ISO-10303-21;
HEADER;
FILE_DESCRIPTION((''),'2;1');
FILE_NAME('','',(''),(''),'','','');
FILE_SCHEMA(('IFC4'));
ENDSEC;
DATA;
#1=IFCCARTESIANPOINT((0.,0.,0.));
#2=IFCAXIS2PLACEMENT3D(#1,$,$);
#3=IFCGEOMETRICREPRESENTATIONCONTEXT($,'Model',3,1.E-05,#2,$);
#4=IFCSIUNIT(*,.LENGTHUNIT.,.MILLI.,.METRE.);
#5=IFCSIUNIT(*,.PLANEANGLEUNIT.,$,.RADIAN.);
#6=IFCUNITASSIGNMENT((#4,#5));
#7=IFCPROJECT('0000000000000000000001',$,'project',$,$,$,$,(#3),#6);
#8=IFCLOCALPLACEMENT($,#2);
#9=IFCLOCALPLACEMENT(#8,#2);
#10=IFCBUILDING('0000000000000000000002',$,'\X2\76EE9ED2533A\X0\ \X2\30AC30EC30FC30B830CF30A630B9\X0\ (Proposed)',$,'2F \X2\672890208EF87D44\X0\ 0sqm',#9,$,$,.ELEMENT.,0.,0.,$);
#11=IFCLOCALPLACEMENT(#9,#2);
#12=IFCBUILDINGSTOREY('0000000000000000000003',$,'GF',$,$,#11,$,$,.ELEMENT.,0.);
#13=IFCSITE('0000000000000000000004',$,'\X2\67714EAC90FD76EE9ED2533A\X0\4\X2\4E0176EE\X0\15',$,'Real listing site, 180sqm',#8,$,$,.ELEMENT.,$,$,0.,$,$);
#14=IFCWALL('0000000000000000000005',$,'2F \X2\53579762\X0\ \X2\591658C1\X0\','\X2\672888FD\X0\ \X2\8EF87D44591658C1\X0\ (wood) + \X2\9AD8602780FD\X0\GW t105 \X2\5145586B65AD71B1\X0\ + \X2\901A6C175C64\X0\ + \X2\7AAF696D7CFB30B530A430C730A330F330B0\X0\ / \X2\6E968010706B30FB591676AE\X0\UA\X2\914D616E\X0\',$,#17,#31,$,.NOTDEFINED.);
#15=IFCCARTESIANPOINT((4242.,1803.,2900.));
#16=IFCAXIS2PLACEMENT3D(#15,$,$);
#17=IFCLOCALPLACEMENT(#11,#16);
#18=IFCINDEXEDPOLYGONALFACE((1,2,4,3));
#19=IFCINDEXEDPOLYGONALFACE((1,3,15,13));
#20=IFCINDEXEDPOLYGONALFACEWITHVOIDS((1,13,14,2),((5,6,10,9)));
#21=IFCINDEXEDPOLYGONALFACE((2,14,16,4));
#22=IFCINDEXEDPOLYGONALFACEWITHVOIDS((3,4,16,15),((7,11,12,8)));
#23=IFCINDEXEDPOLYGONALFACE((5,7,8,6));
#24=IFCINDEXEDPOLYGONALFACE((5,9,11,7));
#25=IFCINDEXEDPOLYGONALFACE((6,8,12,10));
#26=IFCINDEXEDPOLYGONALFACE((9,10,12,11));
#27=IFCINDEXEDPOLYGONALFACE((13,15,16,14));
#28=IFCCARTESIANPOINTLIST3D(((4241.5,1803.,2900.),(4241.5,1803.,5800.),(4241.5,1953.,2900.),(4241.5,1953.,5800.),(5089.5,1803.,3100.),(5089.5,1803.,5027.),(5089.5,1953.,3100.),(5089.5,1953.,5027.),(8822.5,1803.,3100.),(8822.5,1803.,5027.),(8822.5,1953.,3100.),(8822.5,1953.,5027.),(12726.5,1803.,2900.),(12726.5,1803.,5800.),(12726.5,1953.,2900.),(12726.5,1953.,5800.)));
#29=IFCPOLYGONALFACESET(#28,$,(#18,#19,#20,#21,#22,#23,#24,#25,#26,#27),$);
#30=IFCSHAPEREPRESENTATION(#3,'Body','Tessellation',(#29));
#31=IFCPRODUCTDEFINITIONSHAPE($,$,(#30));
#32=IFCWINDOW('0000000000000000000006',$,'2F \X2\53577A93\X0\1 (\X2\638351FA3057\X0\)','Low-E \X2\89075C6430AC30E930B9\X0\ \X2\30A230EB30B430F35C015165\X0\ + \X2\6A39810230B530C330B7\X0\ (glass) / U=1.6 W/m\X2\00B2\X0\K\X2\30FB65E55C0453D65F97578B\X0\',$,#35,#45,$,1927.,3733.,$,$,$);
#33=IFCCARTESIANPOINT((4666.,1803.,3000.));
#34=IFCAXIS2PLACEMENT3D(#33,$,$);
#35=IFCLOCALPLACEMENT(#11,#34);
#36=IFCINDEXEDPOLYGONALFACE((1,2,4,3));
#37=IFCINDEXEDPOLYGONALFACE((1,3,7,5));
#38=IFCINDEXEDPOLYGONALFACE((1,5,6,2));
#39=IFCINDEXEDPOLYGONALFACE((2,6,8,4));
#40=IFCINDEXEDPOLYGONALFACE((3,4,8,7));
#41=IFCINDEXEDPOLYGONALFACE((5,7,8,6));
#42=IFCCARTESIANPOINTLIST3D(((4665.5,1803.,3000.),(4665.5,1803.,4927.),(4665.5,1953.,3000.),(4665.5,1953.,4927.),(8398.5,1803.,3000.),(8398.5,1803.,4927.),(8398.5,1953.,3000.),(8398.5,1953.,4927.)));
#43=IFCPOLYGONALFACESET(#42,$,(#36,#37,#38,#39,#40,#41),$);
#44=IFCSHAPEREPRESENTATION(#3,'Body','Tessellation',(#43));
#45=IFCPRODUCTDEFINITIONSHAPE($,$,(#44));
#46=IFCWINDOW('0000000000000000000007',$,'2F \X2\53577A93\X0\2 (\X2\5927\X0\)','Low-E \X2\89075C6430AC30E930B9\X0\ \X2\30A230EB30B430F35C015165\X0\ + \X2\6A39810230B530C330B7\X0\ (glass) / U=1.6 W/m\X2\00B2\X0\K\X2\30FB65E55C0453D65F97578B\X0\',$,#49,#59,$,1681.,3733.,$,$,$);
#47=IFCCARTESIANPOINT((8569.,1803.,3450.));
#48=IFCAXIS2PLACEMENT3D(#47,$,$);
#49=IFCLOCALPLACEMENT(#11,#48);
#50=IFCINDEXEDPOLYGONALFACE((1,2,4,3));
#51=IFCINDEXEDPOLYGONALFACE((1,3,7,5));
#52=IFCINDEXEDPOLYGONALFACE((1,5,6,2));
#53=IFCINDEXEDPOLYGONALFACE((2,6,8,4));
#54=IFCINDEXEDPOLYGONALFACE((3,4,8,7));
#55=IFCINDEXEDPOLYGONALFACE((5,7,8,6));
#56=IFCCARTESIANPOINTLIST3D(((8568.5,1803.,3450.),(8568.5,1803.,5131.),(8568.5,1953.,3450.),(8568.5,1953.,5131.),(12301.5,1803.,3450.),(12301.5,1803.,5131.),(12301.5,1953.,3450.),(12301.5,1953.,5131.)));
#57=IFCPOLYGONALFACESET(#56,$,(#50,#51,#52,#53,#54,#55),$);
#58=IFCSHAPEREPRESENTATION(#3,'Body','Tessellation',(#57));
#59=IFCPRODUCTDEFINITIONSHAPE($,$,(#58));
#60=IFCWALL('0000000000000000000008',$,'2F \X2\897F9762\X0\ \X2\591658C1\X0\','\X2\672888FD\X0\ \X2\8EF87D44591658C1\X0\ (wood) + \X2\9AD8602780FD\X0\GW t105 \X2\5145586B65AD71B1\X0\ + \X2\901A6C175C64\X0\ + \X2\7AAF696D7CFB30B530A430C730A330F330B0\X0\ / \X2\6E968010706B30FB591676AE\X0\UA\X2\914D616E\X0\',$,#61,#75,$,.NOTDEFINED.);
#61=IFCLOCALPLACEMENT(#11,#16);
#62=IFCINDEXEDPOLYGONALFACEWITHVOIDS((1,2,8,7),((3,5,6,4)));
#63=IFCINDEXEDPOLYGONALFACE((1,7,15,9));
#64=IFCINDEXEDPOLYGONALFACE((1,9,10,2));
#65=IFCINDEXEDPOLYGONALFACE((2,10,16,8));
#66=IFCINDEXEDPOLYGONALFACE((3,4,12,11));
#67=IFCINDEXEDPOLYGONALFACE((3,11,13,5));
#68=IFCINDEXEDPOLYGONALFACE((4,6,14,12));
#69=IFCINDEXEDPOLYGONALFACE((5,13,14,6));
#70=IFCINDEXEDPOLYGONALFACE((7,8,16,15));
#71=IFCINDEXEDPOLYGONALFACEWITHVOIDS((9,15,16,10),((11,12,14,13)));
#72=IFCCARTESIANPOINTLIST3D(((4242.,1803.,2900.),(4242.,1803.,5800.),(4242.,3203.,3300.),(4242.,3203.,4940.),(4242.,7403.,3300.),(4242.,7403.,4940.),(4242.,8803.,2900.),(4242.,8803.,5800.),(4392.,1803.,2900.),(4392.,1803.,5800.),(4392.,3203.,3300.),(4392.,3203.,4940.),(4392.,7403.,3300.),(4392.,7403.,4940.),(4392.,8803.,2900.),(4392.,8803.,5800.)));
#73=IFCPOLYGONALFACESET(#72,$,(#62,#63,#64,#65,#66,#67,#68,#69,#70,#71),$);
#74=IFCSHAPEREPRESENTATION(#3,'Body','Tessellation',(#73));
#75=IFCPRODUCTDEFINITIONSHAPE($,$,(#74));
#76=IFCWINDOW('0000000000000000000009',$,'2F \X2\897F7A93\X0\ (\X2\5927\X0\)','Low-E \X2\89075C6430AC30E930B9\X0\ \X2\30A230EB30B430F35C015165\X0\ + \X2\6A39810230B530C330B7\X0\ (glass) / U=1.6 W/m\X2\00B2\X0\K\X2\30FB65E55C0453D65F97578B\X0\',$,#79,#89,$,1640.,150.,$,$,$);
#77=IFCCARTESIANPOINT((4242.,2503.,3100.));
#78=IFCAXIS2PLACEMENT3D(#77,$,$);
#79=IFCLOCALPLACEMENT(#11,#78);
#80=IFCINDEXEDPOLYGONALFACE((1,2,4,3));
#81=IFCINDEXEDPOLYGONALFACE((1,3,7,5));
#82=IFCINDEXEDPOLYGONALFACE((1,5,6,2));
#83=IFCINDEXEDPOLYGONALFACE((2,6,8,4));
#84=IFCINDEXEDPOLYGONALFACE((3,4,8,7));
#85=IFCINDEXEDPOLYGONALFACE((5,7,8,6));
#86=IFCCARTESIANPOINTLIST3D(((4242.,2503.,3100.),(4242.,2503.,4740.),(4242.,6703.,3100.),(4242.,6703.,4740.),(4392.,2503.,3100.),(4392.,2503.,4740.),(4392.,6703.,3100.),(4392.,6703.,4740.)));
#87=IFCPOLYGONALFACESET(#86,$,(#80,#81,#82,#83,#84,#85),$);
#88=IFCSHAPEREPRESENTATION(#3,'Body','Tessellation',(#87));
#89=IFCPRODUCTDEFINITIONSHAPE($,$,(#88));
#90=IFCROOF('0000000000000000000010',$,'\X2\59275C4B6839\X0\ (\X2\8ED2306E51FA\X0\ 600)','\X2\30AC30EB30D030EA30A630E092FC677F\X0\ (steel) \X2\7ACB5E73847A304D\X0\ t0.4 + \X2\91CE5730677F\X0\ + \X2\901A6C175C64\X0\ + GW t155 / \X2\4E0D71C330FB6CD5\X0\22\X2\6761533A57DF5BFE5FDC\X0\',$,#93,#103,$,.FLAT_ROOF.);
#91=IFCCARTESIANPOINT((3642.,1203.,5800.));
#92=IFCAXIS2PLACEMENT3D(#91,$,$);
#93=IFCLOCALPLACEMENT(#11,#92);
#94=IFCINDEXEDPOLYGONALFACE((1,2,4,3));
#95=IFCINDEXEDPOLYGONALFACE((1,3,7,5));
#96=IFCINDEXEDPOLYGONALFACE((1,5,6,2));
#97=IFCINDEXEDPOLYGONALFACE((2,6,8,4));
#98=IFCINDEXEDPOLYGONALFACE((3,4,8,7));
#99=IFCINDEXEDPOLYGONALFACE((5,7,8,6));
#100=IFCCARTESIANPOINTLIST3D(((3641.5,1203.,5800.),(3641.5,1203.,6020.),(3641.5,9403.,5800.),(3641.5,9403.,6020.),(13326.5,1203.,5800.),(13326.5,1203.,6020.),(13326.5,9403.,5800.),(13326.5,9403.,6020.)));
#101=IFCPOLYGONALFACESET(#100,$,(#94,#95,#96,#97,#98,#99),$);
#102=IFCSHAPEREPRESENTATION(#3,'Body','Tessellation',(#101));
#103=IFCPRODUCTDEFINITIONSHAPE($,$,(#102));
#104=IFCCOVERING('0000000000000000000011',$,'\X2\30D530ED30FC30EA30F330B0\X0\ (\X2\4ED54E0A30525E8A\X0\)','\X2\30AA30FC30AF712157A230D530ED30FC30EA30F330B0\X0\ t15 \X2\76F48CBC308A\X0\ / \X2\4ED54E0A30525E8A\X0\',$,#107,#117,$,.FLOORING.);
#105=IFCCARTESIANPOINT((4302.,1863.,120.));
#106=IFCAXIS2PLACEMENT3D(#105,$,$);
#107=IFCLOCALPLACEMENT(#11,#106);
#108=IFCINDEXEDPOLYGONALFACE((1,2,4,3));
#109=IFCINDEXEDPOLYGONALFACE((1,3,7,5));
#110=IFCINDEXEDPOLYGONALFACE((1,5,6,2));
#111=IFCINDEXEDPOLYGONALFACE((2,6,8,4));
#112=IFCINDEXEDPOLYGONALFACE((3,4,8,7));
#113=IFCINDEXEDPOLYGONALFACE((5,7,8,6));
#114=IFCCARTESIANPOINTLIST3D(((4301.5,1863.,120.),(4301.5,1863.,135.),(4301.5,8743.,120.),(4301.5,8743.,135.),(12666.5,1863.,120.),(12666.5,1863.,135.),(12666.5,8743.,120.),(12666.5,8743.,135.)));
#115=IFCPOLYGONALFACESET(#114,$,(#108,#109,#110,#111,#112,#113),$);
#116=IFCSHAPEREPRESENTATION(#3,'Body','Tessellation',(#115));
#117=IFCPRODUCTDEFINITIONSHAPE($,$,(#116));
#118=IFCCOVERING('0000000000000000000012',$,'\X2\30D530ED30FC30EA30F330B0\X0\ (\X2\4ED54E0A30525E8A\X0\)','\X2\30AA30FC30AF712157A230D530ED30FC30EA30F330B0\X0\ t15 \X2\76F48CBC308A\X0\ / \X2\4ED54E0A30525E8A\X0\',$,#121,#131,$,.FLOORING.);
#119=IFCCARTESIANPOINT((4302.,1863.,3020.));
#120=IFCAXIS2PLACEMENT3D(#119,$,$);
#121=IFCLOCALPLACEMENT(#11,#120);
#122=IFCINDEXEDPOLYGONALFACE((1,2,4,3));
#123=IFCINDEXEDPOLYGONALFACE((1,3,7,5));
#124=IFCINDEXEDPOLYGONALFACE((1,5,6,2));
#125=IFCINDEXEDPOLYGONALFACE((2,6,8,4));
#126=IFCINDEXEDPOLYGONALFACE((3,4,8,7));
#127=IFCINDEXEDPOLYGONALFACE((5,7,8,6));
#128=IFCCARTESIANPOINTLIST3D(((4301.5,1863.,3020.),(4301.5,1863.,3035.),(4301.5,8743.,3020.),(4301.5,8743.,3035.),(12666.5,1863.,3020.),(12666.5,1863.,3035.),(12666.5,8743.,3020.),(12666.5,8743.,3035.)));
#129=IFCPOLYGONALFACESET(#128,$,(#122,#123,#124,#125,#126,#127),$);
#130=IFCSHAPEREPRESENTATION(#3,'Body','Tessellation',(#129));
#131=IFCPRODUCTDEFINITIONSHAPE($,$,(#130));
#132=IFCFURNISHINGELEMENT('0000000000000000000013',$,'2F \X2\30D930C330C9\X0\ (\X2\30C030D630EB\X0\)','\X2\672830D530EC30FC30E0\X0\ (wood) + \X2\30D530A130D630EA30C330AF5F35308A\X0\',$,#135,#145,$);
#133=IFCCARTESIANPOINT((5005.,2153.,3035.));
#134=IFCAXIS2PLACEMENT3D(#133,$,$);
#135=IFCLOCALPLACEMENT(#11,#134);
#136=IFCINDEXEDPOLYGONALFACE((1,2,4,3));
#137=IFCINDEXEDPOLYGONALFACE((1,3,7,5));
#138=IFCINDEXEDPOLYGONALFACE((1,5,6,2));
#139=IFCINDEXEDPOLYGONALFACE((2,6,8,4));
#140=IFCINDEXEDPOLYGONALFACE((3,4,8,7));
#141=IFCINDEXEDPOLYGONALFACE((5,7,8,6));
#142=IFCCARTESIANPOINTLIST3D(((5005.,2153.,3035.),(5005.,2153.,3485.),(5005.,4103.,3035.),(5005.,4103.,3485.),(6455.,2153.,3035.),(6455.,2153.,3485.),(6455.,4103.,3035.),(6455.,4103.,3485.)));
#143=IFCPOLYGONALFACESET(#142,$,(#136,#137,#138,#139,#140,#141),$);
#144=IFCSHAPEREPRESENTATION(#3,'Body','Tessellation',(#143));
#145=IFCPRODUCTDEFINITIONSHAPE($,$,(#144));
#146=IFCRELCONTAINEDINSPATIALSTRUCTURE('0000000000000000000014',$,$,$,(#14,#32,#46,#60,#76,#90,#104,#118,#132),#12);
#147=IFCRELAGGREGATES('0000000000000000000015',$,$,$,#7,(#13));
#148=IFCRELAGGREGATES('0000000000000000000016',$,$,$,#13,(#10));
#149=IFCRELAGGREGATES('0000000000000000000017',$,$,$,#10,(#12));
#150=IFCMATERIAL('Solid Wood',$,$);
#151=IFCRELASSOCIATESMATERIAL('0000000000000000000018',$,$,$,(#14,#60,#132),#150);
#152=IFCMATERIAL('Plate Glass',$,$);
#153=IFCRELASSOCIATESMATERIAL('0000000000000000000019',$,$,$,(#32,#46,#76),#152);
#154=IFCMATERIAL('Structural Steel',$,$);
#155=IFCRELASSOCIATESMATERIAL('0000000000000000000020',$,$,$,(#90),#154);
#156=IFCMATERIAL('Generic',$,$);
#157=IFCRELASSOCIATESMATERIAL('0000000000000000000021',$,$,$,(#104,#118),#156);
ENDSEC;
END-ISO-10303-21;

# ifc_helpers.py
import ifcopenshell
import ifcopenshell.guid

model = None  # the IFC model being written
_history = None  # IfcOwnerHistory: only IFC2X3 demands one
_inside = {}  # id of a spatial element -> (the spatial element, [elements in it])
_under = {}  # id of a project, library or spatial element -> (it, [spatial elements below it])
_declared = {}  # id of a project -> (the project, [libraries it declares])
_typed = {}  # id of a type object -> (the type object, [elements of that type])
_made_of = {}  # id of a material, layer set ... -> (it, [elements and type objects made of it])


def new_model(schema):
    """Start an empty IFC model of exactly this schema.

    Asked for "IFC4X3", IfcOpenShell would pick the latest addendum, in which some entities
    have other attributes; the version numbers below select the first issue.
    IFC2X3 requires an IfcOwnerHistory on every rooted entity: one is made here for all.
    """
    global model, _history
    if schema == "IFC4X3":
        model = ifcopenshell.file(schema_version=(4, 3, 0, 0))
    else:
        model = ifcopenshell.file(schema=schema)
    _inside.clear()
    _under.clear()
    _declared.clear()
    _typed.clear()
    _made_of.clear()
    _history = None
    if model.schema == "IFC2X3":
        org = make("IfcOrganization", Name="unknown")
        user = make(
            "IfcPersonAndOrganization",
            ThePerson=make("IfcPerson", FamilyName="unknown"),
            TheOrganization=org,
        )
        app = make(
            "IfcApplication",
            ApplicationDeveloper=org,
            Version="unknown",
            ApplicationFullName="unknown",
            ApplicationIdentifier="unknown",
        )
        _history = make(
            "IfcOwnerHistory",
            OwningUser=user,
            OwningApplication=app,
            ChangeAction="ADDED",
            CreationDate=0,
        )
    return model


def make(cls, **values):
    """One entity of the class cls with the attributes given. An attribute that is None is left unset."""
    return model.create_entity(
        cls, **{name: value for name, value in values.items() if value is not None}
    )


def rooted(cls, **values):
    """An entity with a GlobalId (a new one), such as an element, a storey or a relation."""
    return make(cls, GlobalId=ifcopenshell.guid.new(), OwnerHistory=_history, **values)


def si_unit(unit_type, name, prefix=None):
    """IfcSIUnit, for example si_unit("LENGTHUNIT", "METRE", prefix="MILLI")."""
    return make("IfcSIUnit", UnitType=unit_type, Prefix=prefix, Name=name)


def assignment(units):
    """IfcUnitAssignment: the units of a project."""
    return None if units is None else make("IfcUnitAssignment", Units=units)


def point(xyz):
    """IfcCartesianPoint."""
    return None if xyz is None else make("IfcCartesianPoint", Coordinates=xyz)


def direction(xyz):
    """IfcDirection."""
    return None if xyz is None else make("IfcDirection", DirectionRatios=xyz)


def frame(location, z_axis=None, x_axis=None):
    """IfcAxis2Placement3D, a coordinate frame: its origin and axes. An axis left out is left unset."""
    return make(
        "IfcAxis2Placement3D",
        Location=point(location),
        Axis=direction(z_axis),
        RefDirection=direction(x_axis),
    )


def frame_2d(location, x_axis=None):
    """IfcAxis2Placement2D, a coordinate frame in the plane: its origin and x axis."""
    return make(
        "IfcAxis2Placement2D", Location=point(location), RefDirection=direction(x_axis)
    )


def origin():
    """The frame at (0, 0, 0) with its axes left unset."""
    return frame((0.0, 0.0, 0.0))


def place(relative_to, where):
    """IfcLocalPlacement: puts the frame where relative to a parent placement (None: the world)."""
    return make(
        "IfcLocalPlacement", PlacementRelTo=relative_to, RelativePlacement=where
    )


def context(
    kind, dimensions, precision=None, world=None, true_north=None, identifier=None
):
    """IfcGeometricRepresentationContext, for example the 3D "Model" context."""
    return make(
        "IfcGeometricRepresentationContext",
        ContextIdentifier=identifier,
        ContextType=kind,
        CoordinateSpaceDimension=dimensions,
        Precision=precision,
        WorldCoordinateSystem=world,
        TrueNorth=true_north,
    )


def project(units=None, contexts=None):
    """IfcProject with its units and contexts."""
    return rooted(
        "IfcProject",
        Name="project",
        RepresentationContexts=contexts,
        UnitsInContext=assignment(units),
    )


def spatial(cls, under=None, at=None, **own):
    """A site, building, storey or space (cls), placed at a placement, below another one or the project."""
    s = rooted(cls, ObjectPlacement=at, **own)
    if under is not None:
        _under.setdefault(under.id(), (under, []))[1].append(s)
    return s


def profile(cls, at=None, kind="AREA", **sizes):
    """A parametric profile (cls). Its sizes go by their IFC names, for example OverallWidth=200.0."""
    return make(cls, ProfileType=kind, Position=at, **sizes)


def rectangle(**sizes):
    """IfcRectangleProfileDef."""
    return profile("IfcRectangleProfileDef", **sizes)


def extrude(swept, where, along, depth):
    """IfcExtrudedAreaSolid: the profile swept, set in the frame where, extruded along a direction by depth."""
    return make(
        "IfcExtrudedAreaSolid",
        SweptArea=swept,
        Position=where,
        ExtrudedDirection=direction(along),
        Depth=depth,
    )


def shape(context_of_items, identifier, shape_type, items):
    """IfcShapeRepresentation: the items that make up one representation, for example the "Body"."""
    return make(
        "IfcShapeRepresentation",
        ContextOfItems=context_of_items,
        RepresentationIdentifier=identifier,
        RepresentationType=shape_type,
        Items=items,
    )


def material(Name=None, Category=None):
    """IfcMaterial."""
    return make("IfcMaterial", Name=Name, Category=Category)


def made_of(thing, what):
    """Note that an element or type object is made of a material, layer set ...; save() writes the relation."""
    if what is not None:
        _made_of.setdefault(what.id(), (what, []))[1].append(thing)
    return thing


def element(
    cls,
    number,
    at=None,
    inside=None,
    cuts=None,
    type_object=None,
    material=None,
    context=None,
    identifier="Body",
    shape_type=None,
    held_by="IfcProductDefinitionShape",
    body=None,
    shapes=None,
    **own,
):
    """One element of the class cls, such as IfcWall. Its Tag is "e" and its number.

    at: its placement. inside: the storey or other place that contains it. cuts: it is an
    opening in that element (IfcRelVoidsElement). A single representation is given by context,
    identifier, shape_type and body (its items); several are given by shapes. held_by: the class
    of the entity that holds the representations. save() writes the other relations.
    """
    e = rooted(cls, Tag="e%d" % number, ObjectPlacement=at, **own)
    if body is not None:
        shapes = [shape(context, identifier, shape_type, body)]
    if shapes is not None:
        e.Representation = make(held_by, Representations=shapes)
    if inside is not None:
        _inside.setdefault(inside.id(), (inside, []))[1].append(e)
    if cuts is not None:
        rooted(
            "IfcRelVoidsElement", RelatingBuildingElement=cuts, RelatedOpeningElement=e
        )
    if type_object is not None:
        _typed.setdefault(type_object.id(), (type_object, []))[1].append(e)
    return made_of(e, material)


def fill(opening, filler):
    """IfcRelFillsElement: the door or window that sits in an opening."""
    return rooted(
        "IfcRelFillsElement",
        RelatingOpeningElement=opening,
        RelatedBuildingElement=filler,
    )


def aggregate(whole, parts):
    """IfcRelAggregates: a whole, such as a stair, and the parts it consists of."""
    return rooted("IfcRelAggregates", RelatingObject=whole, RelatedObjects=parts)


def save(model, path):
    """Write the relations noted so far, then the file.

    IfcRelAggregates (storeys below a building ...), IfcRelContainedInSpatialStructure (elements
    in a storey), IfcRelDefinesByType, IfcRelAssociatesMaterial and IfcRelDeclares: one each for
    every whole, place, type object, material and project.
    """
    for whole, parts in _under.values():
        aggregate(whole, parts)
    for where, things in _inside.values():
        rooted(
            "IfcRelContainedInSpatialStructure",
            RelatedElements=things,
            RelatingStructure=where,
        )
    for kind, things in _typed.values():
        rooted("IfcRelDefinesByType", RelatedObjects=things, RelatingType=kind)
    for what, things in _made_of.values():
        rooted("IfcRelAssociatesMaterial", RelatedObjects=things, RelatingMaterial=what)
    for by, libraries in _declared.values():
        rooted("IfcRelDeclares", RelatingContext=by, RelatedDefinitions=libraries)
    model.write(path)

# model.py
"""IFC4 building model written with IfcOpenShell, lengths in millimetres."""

from ifc_helpers import new_model, si_unit, frame, frame_2d, origin, place, context, project, spatial, rectangle, extrude, material, element, fill, save


model = new_model("IFC4")

# Units and contexts
model_context = context("Model", 3, precision=1e-05, world=origin())
ifc_project = project(units=[si_unit("LENGTHUNIT", "METRE", prefix="MILLI"), si_unit("PLANEANGLEUNIT", "RADIAN")], contexts=[model_context])

# Site, building, storey
site_placement = place(None, origin())
site = spatial("IfcSite", under=ifc_project, at=site_placement, Name="東京都目黒区4丁目15", ObjectType="Real listing site, 180sqm", CompositionType="ELEMENT", RefElevation=0.0)
building_placement = place(site_placement, origin())
building = spatial("IfcBuilding", under=site, at=building_placement, Name="目黒区 ガレージハウス (Proposed)", ObjectType="2F 木造軸組 0sqm", CompositionType="ELEMENT", ElevationOfRefHeight=0.0, ElevationOfTerrain=0.0)
storey_placement = place(building_placement, origin())
storey = spatial("IfcBuildingStorey", under=building, at=storey_placement, Name="GF", CompositionType="ELEMENT", Elevation=0.0)

# Shared definitions
ifc_material_1 = material(Name="Solid Wood")

# Shared definitions
ifc_material_2 = material(Name="Plate Glass")

# Wall, openings, windows
wall_1_placement = place(storey_placement, frame((4242.0, 1803.0, 2900.0)))
wall_1 = element("IfcWall", 1, at=wall_1_placement, inside=storey, material=ifc_material_1, Name="2F 南面 外壁", Description="木製 軸組外壁 (wood) + 高性能GW t105 充填断熱 + 通気層 + 窯業系サイディング / 準耐火・外皮UA配慮", PredefinedType="NOTDEFINED", context=model_context, shape_type="SweptSolid", body=[
    extrude(rectangle(XDim=8485.0, YDim=150.0, at=frame_2d((4242.0, 75.0))), frame((4242.0, 1803.0, 2900.0)), (0.0, 0.0, 1.0), 2900.0),
])
opening_1_placement = place(storey_placement, frame((4666.0, 1803.0, 3000.0)))
opening_1 = element("IfcOpeningElement", 2, at=opening_1_placement, cuts=wall_1, PredefinedType="NOTDEFINED", context=model_context, shape_type="SweptSolid", body=[
    extrude(rectangle(XDim=3733.0, YDim=150.0, at=frame_2d((1866.0, 75.0))), frame((4666.0, 1803.0, 3000.0)), (0.0, 0.0, 1.0), 1927.0),
])
opening_2_placement = place(storey_placement, frame((8569.0, 1803.0, 3450.0)))
opening_2 = element("IfcOpeningElement", 3, at=opening_2_placement, cuts=wall_1, PredefinedType="NOTDEFINED", context=model_context, shape_type="SweptSolid", body=[
    extrude(rectangle(XDim=3733.0, YDim=150.0, at=frame_2d((1866.0, 75.0))), frame((8569.0, 1803.0, 3450.0)), (0.0, 0.0, 1.0), 1681.0),
])
window_1_placement = place(storey_placement, frame((4666.0, 1803.0, 3000.0)))
window_1 = element("IfcWindow", 4, at=window_1_placement, inside=storey, material=ifc_material_2, Name="2F 南窓1 (掃出し)", Description="Low-E 複層ガラス アルゴン封入 + 樹脂サッシ (glass) / U=1.6 W/m²K・日射取得型", OverallHeight=1927.0, OverallWidth=3733.0, context=model_context, shape_type="SweptSolid", body=[
    extrude(rectangle(XDim=3733.0, YDim=150.0, at=frame_2d((1866.0, 75.0))), frame((4666.0, 1803.0, 3000.0)), (0.0, 0.0, 1.0), 1927.0),
])
fill(opening_1, window_1)
window_2_placement = place(storey_placement, frame((8569.0, 1803.0, 3450.0)))
window_2 = element("IfcWindow", 5, at=window_2_placement, inside=storey, material=ifc_material_2, Name="2F 南窓2 (大)", Description="Low-E 複層ガラス アルゴン封入 + 樹脂サッシ (glass) / U=1.6 W/m²K・日射取得型", OverallHeight=1681.0, OverallWidth=3733.0, context=model_context, shape_type="SweptSolid", body=[
    extrude(rectangle(XDim=3733.0, YDim=150.0, at=frame_2d((1866.0, 75.0))), frame((8569.0, 1803.0, 3450.0)), (0.0, 0.0, 1.0), 1681.0),
])
fill(opening_2, window_2)

# Wall, opening, window
wall_2_placement = place(storey_placement, frame((4242.0, 1803.0, 2900.0)))
wall_2 = element("IfcWall", 6, at=wall_2_placement, inside=storey, material=ifc_material_1, Name="2F 西面 外壁", Description="木製 軸組外壁 (wood) + 高性能GW t105 充填断熱 + 通気層 + 窯業系サイディング / 準耐火・外皮UA配慮", PredefinedType="NOTDEFINED", context=model_context, shape_type="SweptSolid", body=[
    extrude(rectangle(XDim=150.0, YDim=7000.0, at=frame_2d((75.0, 3500.0))), frame((4242.0, 1803.0, 2900.0)), (0.0, 0.0, 1.0), 2900.0),
])
opening_3_placement = place(storey_placement, frame((4242.0, 2503.0, 3100.0)))
opening_3 = element("IfcOpeningElement", 7, at=opening_3_placement, cuts=wall_2, PredefinedType="NOTDEFINED", context=model_context, shape_type="SweptSolid", body=[
    extrude(rectangle(XDim=150.0, YDim=4200.0, at=frame_2d((75.0, 2100.0))), frame((4242.0, 2503.0, 3100.0)), (0.0, 0.0, 1.0), 1640.0),
])
window_3_placement = place(storey_placement, frame((4242.0, 2503.0, 3100.0)))
window_3 = element("IfcWindow", 8, at=window_3_placement, inside=storey, material=ifc_material_2, Name="2F 西窓 (大)", Description="Low-E 複層ガラス アルゴン封入 + 樹脂サッシ (glass) / U=1.6 W/m²K・日射取得型", OverallHeight=1640.0, OverallWidth=150.0, context=model_context, shape_type="SweptSolid", body=[
    extrude(rectangle(XDim=150.0, YDim=4200.0, at=frame_2d((75.0, 2100.0))), frame((4242.0, 2503.0, 3100.0)), (0.0, 0.0, 1.0), 1640.0),
])
fill(opening_3, window_3)

# Roof
ifc_material_3 = material(Name="Structural Steel")
roof_placement = place(storey_placement, frame((3642.0, 1203.0, 5800.0)))
element("IfcRoof", 9, at=roof_placement, inside=storey, material=ifc_material_3, Name="大屋根 (軒の出 600)", Description="ガルバリウム鋼板 (steel) 立平葺き t0.4 + 野地板 + 通気層 + GW t155 / 不燃・法22条区域対応", PredefinedType="FLAT_ROOF", context=model_context, shape_type="SweptSolid", body=[
    extrude(rectangle(XDim=9685.0, YDim=8200.0, at=frame_2d((4842.0, 4100.0))), frame((3642.0, 1203.0, 5800.0)), (0.0, 0.0, 1.0), 220.0),
])

# Coverings
ifc_material_4 = material(Name="Generic")
covering_1_placement = place(storey_placement, frame((4302.0, 1863.0, 120.0)))
element("IfcCovering", 10, at=covering_1_placement, inside=storey, material=ifc_material_4, Name="フローリング (仕上げ床)", Description="オーク無垢フローリング t15 直貼り / 仕上げ床", PredefinedType="FLOORING", context=model_context, shape_type="SweptSolid", body=[
    extrude(rectangle(XDim=8365.0, YDim=6880.0, at=frame_2d((4182.0, 3440.0))), frame((4302.0, 1863.0, 120.0)), (0.0, 0.0, 1.0), 15.0),
])
covering_2_placement = place(storey_placement, frame((4302.0, 1863.0, 3020.0)))
element("IfcCovering", 11, at=covering_2_placement, inside=storey, material=ifc_material_4, Name="フローリング (仕上げ床)", Description="オーク無垢フローリング t15 直貼り / 仕上げ床", PredefinedType="FLOORING", context=model_context, shape_type="SweptSolid", body=[
    extrude(rectangle(XDim=8365.0, YDim=6880.0, at=frame_2d((4182.0, 3440.0))), frame((4302.0, 1863.0, 3020.0)), (0.0, 0.0, 1.0), 15.0),
])

# Furnishing element
furnishing_placement = place(storey_placement, frame((5005.0, 2153.0, 3035.0)))
element("IfcFurnishingElement", 12, at=furnishing_placement, inside=storey, material=ifc_material_1, Name="2F ベッド (ダブル)", Description="木フレーム (wood) + ファブリック張り", context=model_context, shape_type="SweptSolid", body=[
    extrude(rectangle(XDim=1450.0, YDim=1950.0, at=frame_2d((725.0, 975.0))), frame((5005.0, 2153.0, 3035.0)), (0.0, 0.0, 1.0), 450.0),
])

save(model, "model.ifc")
